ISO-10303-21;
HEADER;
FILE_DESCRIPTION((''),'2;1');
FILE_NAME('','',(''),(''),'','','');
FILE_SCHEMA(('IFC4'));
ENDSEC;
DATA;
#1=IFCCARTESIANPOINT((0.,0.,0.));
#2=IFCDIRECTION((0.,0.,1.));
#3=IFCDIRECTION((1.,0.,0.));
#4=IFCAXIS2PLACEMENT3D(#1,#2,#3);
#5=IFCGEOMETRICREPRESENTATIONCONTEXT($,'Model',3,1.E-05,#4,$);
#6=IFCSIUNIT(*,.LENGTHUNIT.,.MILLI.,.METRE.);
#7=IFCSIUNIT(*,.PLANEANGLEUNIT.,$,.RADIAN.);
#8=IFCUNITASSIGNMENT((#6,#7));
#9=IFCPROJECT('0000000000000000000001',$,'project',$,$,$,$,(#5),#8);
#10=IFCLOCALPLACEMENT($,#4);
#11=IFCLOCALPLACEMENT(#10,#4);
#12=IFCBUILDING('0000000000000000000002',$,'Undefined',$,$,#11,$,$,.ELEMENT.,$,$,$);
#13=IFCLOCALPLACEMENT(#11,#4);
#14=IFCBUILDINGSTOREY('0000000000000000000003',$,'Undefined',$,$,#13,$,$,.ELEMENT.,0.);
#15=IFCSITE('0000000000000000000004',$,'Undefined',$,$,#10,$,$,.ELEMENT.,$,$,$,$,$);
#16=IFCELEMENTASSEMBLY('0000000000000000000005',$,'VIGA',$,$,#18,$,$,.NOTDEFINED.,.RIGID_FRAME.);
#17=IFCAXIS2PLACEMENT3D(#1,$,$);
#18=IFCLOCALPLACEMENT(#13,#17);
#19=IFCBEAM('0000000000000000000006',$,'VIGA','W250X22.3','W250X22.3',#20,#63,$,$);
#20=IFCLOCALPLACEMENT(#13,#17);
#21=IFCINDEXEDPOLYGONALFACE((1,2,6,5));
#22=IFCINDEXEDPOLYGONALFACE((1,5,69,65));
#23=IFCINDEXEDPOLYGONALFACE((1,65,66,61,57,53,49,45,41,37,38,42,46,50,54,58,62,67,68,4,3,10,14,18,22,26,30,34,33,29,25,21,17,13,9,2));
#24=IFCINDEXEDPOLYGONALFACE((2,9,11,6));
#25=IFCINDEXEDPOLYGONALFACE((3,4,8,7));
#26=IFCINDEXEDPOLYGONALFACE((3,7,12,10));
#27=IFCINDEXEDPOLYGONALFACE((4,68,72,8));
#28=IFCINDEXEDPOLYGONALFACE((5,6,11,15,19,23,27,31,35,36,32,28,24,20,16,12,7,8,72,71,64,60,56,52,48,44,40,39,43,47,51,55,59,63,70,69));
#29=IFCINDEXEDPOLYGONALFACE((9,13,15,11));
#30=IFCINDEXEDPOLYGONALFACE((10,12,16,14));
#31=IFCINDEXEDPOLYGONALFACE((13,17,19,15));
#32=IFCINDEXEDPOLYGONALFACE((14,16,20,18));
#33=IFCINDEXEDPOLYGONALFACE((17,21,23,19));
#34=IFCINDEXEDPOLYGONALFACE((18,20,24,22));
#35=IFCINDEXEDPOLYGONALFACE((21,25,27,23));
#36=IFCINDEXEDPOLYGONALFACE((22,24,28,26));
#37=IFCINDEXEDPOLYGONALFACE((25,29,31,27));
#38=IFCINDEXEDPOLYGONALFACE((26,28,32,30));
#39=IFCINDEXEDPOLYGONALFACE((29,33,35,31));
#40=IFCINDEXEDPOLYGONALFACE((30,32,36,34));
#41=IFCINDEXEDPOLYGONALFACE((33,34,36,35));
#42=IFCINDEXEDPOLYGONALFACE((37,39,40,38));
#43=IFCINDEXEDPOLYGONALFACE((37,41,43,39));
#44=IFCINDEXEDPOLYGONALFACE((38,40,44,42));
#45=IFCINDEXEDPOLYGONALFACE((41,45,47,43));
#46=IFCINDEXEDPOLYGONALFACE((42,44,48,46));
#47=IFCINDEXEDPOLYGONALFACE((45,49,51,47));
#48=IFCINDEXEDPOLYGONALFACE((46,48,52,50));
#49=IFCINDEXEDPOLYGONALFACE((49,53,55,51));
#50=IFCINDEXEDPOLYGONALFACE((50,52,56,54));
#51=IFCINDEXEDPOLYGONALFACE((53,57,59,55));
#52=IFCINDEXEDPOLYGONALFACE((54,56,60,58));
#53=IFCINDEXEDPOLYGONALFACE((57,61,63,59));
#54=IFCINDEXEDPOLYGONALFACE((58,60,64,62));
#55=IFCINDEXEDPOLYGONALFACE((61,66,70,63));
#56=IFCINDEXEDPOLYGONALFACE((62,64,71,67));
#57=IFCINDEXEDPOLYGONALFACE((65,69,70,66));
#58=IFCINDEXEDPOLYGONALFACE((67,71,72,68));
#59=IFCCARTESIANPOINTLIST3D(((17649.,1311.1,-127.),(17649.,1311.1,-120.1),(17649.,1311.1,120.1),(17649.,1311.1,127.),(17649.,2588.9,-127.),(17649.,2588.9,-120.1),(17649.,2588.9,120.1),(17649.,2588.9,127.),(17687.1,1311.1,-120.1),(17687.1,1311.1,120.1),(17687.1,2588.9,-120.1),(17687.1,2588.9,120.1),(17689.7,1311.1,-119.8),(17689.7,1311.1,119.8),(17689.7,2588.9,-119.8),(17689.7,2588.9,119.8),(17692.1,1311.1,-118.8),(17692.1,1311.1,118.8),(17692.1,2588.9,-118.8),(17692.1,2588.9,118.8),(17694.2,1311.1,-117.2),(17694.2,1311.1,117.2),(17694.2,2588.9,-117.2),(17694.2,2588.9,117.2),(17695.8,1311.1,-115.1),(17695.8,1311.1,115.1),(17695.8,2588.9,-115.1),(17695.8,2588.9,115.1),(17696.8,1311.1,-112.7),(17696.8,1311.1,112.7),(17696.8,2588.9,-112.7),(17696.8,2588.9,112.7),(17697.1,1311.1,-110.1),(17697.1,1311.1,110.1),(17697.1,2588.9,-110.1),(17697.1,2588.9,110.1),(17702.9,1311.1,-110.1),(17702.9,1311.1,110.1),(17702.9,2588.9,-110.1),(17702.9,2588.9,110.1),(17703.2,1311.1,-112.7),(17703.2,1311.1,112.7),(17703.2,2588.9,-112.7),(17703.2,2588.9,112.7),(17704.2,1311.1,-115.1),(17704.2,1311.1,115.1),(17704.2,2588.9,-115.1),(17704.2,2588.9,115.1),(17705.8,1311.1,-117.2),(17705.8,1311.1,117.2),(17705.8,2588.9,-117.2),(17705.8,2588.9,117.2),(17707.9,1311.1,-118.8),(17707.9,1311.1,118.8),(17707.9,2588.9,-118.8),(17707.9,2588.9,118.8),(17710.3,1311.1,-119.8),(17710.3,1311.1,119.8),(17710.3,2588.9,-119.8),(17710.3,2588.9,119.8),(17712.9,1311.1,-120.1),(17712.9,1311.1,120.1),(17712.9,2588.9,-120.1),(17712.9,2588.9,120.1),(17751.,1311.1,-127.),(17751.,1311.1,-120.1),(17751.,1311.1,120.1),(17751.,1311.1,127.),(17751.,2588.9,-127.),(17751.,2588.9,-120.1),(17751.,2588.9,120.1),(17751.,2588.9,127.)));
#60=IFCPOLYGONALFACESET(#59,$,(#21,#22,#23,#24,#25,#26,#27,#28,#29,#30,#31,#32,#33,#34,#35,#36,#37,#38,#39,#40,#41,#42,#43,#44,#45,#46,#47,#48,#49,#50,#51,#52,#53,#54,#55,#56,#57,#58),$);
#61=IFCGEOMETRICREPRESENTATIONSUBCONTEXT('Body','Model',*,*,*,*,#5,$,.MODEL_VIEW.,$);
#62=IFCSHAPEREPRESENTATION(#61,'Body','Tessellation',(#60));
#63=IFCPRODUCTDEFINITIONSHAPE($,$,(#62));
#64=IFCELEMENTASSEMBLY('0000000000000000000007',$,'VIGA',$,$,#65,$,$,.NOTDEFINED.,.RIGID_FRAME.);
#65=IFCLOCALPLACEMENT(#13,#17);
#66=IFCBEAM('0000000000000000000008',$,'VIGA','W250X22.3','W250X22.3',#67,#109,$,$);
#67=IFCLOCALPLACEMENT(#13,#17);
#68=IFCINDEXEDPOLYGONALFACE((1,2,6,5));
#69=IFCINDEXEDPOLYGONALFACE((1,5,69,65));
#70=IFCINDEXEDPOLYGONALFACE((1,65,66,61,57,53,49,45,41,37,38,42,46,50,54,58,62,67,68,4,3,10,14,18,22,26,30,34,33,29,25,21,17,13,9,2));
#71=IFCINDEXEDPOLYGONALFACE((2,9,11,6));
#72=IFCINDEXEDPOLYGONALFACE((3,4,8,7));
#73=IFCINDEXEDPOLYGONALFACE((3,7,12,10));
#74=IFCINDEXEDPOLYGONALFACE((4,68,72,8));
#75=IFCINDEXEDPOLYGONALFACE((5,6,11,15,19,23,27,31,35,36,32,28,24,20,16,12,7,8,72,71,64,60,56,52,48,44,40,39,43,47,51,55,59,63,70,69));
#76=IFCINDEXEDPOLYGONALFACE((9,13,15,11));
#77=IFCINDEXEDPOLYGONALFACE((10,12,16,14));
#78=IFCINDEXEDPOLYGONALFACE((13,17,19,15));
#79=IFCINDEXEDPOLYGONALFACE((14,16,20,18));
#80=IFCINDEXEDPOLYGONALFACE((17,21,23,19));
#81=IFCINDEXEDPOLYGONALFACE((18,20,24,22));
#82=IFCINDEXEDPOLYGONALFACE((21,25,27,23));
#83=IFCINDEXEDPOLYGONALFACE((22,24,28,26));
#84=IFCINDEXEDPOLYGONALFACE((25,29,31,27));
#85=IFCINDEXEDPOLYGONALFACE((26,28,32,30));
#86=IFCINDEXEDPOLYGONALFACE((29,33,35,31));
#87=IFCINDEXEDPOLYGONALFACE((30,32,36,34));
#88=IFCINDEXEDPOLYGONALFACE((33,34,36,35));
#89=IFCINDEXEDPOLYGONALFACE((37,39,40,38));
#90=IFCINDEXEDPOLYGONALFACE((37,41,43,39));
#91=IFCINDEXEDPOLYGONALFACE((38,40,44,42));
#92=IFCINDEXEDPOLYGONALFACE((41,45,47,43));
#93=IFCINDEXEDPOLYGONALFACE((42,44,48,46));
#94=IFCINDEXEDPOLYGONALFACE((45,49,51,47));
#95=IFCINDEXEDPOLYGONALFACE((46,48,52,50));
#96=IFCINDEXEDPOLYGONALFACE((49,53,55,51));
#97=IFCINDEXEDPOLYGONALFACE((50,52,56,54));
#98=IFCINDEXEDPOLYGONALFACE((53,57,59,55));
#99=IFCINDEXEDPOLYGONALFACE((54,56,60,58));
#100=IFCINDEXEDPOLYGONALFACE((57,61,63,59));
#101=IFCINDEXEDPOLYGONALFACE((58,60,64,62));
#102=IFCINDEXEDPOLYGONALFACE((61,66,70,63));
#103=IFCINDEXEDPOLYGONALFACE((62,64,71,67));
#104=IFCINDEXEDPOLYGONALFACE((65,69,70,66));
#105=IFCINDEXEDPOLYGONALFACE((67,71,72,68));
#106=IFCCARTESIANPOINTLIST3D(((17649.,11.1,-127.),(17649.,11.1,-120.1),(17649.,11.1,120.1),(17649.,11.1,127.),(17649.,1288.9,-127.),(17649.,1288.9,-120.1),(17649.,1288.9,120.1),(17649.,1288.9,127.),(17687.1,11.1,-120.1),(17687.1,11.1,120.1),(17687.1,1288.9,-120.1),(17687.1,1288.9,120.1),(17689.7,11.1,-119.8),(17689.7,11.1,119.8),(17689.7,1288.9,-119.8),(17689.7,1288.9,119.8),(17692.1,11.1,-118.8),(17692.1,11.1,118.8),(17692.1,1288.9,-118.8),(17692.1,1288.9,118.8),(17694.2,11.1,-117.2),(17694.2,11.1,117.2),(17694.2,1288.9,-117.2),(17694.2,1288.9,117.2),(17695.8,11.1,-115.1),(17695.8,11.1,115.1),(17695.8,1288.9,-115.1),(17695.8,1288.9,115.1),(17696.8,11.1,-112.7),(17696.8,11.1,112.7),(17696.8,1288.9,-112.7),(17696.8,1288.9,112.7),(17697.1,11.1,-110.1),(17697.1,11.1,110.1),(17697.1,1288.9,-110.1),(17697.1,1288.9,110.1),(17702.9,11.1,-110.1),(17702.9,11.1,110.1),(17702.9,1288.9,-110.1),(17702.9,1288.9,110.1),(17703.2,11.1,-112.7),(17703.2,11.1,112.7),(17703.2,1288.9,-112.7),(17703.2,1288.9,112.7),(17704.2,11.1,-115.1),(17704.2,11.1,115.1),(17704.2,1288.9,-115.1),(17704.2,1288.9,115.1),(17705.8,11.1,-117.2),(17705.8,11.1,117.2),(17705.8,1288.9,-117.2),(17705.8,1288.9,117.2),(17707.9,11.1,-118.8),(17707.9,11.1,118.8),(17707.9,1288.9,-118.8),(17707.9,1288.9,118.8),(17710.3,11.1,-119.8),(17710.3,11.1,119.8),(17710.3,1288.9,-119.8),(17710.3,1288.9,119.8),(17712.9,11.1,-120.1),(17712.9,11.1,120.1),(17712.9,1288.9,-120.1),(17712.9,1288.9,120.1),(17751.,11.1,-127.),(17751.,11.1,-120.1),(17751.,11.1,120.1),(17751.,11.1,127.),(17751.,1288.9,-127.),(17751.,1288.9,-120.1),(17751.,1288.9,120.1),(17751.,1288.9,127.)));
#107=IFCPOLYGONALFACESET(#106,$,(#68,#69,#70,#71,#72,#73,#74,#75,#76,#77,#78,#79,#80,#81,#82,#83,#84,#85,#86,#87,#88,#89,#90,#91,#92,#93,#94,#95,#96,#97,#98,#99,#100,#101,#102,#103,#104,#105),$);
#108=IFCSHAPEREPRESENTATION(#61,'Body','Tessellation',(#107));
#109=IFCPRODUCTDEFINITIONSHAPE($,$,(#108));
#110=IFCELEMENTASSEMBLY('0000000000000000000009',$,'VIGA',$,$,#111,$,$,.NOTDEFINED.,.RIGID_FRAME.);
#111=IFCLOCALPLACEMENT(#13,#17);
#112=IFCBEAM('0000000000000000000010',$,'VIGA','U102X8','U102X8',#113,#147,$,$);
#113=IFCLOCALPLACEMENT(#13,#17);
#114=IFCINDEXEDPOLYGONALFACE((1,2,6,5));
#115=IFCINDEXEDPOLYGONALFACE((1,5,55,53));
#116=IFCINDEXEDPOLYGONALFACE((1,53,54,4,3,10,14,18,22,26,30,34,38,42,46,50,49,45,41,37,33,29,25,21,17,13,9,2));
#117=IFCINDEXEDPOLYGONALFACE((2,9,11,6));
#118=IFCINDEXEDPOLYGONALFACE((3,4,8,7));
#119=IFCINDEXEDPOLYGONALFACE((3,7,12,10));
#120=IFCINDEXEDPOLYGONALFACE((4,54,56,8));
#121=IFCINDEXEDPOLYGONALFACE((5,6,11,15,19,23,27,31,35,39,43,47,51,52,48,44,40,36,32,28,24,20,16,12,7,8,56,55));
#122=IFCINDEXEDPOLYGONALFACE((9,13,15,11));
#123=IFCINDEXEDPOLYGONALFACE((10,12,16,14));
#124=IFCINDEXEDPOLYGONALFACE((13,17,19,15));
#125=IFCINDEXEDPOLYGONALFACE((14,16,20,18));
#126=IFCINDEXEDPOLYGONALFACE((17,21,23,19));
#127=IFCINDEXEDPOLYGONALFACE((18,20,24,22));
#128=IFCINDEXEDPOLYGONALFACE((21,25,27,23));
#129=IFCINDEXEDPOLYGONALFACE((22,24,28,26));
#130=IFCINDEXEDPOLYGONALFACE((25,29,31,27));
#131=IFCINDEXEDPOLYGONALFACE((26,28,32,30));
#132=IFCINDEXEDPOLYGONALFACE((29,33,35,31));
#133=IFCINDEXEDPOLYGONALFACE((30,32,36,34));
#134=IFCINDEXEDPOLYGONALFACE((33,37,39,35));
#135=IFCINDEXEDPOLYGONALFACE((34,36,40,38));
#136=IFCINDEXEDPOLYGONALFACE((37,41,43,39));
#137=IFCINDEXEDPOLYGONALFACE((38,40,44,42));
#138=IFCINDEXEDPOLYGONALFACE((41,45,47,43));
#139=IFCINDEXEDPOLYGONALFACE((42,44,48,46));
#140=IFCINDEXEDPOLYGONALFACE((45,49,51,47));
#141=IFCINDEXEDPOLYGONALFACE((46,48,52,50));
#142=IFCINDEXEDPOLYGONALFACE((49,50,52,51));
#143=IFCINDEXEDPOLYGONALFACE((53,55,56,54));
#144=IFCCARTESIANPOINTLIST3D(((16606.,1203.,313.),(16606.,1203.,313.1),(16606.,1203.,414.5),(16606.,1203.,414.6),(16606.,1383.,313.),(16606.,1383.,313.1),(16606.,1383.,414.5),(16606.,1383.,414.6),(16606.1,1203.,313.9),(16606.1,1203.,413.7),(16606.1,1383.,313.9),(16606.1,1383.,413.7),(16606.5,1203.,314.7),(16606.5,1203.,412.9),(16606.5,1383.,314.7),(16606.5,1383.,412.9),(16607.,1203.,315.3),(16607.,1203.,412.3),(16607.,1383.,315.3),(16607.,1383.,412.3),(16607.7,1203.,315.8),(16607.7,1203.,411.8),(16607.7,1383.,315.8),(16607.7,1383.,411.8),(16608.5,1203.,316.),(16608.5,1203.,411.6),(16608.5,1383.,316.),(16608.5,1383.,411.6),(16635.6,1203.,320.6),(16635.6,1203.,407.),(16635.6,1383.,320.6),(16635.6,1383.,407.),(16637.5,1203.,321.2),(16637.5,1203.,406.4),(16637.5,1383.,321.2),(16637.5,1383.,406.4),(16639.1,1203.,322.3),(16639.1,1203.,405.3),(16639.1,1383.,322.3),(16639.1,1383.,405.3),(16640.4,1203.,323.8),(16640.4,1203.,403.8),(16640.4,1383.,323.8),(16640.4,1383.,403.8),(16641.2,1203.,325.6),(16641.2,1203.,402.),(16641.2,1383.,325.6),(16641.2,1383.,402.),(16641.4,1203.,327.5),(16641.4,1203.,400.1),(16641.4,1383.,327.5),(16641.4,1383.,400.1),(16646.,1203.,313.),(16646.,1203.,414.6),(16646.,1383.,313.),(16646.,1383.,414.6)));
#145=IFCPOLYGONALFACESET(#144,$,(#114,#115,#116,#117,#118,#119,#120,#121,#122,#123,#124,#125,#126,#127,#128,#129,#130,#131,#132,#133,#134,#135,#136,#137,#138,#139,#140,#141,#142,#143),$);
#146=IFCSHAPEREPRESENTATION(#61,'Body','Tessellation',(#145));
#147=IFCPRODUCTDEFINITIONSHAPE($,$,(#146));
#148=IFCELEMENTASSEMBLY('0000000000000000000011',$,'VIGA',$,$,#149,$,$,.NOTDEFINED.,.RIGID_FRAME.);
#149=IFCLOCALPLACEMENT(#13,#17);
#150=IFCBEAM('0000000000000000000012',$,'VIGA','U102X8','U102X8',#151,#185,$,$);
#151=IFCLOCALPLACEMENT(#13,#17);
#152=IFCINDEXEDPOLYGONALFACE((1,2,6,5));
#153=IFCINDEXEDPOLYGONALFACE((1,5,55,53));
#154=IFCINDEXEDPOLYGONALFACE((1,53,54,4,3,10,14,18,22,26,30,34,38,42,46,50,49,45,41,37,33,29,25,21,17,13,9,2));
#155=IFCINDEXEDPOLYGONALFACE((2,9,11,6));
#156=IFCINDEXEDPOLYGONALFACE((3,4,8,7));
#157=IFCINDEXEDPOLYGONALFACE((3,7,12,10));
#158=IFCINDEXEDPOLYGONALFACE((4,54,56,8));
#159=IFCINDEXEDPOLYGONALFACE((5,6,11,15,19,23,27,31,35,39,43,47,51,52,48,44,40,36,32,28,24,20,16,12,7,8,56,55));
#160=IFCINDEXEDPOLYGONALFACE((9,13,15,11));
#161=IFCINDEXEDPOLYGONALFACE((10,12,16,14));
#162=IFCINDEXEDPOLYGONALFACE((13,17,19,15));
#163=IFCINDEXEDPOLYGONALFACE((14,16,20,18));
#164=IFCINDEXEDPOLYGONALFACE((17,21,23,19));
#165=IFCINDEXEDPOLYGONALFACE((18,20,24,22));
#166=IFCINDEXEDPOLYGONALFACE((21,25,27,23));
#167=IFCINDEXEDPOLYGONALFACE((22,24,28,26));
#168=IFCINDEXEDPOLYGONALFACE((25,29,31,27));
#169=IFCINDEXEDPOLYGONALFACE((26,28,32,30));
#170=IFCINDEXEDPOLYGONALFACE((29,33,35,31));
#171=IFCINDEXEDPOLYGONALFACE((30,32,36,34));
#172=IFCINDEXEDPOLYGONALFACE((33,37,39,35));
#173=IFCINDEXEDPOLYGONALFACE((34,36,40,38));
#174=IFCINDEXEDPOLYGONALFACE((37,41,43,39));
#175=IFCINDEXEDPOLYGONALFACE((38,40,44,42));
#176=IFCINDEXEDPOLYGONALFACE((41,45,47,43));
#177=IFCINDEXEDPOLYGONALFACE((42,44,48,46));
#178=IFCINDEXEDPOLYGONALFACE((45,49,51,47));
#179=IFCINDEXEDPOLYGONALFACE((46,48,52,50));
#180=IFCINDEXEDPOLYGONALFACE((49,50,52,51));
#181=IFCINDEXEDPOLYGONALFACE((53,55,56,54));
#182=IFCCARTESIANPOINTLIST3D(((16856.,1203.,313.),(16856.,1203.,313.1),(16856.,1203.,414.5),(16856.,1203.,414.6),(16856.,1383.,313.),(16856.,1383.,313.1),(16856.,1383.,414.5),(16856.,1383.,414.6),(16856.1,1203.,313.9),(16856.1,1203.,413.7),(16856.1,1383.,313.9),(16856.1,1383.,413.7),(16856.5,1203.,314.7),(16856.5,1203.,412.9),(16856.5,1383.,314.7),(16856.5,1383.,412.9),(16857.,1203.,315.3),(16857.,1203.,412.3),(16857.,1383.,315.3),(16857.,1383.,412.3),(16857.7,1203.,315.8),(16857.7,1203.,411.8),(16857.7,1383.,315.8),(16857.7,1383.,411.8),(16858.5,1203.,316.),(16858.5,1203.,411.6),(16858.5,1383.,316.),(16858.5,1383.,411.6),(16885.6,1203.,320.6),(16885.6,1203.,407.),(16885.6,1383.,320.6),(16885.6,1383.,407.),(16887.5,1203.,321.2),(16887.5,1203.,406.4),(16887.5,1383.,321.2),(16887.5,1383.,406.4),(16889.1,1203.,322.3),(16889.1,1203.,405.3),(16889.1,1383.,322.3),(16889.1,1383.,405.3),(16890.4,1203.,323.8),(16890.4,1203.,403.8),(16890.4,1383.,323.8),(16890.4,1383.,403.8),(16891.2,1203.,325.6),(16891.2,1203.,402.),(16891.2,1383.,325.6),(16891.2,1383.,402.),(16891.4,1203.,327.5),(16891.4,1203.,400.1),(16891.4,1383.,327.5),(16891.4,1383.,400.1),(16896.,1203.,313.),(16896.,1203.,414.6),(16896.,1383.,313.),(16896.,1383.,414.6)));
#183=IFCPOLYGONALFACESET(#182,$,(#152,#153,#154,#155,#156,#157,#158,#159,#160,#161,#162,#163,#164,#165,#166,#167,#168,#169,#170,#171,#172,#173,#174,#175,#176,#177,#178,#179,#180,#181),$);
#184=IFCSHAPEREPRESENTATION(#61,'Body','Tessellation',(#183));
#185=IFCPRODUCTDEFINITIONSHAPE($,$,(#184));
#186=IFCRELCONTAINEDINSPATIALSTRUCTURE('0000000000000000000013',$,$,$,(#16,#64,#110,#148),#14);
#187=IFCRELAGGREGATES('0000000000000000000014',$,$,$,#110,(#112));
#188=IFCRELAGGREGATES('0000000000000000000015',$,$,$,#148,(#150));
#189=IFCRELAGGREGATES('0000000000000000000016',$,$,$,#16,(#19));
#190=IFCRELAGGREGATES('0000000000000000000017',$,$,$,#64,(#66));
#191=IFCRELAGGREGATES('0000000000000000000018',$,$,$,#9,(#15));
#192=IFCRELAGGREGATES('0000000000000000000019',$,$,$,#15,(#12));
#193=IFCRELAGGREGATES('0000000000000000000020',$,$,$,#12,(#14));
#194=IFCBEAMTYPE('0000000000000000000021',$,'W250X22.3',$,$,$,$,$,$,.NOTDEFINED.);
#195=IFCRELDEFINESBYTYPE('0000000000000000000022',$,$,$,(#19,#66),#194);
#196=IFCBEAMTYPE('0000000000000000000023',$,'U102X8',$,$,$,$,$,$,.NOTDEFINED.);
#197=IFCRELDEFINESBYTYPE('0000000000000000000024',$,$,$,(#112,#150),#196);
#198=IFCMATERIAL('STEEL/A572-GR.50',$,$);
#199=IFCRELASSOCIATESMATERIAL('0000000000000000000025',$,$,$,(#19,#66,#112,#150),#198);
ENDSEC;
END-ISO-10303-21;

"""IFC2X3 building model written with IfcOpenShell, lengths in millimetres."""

from ifc_helpers import new_model, si_unit, frame, origin_with_axes, origin_2d_with_axis, place, context, subcontext, project, spatial, i_section, u_section, extrude, material, type_object, element, aggregate, save


model = new_model("IFC2X3")

# Units and contexts
model_context = context("Model", 3, precision=1e-05, world=origin_with_axes())
body_context = subcontext(model_context, "Body", "Model", "MODEL_VIEW")
ifc_project = project(units=[si_unit("LENGTHUNIT", "METRE", prefix="MILLI"), si_unit("PLANEANGLEUNIT", "RADIAN")], contexts=[model_context])

# Site, building, storey
site_placement = place(None, origin_with_axes())
site = spatial("IfcSite", under=ifc_project, at=site_placement, Name="Undefined", CompositionType="ELEMENT")
building_placement = place(site_placement, origin_with_axes())
building = spatial("IfcBuilding", under=site, at=building_placement, Name="Undefined", CompositionType="ELEMENT")
storey_placement = place(building_placement, origin_with_axes())
storey = spatial("IfcBuildingStorey", under=building, at=storey_placement, Name="Undefined", CompositionType="ELEMENT", Elevation=0.0)

# Element assemblies, beams
assembly_1_placement = place(storey_placement, origin_with_axes())
assembly_1 = element("IfcElementAssembly", 1, at=assembly_1_placement, inside=storey, Name="VIGA", AssemblyPlace="NOTDEFINED", PredefinedType="RIGID_FRAME")
ifc_material_1 = material(Name="STEEL/A572-GR.50")
beam_type_1 = type_object("IfcBeamType", Name="W250X22.3", PredefinedType="NOTDEFINED")
beam_1_placement = place(assembly_1_placement, frame((17700.0, 1311.1, 0.0), z_axis=(0.0, 0.0, 1.0), x_axis=(0.0, 1.0, 0.0)))
beam_1 = element("IfcBeam", 2, at=beam_1_placement, type_object=beam_type_1, material=ifc_material_1, Name="VIGA", Description="W250X22.3", ObjectType="W250X22.3", context=body_context, shape_type="SweptSolid", body=[
    extrude(i_section(OverallWidth=102.0, OverallDepth=254.0, WebThickness=5.8, FlangeThickness=6.9, FilletRadius=10.0, at=origin_2d_with_axis()), frame((1277.8, 0.0, 0.0), z_axis=(-1.0, 0.0, 0.0), x_axis=(0.0, -1.0, 0.0)), (0.0, 0.0, 1.0), 1277.8),
])
assembly_2_placement = place(storey_placement, origin_with_axes())
assembly_2 = element("IfcElementAssembly", 3, at=assembly_2_placement, inside=storey, Name="VIGA", AssemblyPlace="NOTDEFINED", PredefinedType="RIGID_FRAME")
beam_2_placement = place(assembly_2_placement, frame((17700.0, 11.1, 0.0), z_axis=(0.0, 0.0, 1.0), x_axis=(0.0, 1.0, 0.0)))
beam_2 = element("IfcBeam", 4, at=beam_2_placement, type_object=beam_type_1, material=ifc_material_1, Name="VIGA", Description="W250X22.3", ObjectType="W250X22.3", context=body_context, shape_type="SweptSolid", body=[
    extrude(i_section(OverallWidth=102.0, OverallDepth=254.0, WebThickness=5.8, FlangeThickness=6.9, FilletRadius=10.0, at=origin_2d_with_axis()), frame((1277.8, 0.0, 0.0), z_axis=(-1.0, 0.0, 0.0), x_axis=(0.0, -1.0, 0.0)), (0.0, 0.0, 1.0), 1277.8),
])
assembly_3_placement = place(storey_placement, origin_with_axes())
assembly_3 = element("IfcElementAssembly", 5, at=assembly_3_placement, inside=storey, Name="VIGA", AssemblyPlace="NOTDEFINED", PredefinedType="RIGID_FRAME")
beam_type_2 = type_object("IfcBeamType", Name="U102X8", PredefinedType="NOTDEFINED")
beam_3_placement = place(assembly_3_placement, frame((16626.0, 1383.0, 363.8), z_axis=(0.0, 0.0, 1.0), x_axis=(0.0, -1.0, 0.0)))
beam_3 = element("IfcBeam", 6, at=beam_3_placement, type_object=beam_type_2, material=ifc_material_1, Name="VIGA", Description="U102X8", ObjectType="U102X8", context=body_context, shape_type="SweptSolid", body=[
    extrude(u_section(Depth=101.6, FlangeWidth=40.0, WebThickness=4.6, FlangeThickness=6.0, FilletRadius=7.0, EdgeRadius=3.0, FlangeSlope=0.16839, at=origin_2d_with_axis()), frame((180.0, 0.0, 0.0), z_axis=(-1.0, 0.0, 0.0), x_axis=(0.0, -1.0, 0.0)), (0.0, 0.0, 1.0), 180.0),
])
aggregate(assembly_3, [beam_3])
assembly_4_placement = place(storey_placement, origin_with_axes())
assembly_4 = element("IfcElementAssembly", 7, at=assembly_4_placement, inside=storey, Name="VIGA", AssemblyPlace="NOTDEFINED", PredefinedType="RIGID_FRAME")
beam_4_placement = place(assembly_4_placement, frame((16876.0, 1383.0, 363.8), z_axis=(0.0, 0.0, 1.0), x_axis=(0.0, -1.0, 0.0)))
beam_4 = element("IfcBeam", 8, at=beam_4_placement, type_object=beam_type_2, material=ifc_material_1, Name="VIGA", Description="U102X8", ObjectType="U102X8", context=body_context, shape_type="SweptSolid", body=[
    extrude(u_section(Depth=101.6, FlangeWidth=40.0, WebThickness=4.6, FlangeThickness=6.0, FilletRadius=7.0, EdgeRadius=3.0, FlangeSlope=0.16839, at=origin_2d_with_axis()), frame((180.0, 0.0, 0.0), z_axis=(-1.0, 0.0, 0.0), x_axis=(0.0, -1.0, 0.0)), (0.0, 0.0, 1.0), 180.0),
])
aggregate(assembly_4, [beam_4])

aggregate(assembly_1, [beam_1])
aggregate(assembly_2, [beam_2])

save(model, "model.ifc")
